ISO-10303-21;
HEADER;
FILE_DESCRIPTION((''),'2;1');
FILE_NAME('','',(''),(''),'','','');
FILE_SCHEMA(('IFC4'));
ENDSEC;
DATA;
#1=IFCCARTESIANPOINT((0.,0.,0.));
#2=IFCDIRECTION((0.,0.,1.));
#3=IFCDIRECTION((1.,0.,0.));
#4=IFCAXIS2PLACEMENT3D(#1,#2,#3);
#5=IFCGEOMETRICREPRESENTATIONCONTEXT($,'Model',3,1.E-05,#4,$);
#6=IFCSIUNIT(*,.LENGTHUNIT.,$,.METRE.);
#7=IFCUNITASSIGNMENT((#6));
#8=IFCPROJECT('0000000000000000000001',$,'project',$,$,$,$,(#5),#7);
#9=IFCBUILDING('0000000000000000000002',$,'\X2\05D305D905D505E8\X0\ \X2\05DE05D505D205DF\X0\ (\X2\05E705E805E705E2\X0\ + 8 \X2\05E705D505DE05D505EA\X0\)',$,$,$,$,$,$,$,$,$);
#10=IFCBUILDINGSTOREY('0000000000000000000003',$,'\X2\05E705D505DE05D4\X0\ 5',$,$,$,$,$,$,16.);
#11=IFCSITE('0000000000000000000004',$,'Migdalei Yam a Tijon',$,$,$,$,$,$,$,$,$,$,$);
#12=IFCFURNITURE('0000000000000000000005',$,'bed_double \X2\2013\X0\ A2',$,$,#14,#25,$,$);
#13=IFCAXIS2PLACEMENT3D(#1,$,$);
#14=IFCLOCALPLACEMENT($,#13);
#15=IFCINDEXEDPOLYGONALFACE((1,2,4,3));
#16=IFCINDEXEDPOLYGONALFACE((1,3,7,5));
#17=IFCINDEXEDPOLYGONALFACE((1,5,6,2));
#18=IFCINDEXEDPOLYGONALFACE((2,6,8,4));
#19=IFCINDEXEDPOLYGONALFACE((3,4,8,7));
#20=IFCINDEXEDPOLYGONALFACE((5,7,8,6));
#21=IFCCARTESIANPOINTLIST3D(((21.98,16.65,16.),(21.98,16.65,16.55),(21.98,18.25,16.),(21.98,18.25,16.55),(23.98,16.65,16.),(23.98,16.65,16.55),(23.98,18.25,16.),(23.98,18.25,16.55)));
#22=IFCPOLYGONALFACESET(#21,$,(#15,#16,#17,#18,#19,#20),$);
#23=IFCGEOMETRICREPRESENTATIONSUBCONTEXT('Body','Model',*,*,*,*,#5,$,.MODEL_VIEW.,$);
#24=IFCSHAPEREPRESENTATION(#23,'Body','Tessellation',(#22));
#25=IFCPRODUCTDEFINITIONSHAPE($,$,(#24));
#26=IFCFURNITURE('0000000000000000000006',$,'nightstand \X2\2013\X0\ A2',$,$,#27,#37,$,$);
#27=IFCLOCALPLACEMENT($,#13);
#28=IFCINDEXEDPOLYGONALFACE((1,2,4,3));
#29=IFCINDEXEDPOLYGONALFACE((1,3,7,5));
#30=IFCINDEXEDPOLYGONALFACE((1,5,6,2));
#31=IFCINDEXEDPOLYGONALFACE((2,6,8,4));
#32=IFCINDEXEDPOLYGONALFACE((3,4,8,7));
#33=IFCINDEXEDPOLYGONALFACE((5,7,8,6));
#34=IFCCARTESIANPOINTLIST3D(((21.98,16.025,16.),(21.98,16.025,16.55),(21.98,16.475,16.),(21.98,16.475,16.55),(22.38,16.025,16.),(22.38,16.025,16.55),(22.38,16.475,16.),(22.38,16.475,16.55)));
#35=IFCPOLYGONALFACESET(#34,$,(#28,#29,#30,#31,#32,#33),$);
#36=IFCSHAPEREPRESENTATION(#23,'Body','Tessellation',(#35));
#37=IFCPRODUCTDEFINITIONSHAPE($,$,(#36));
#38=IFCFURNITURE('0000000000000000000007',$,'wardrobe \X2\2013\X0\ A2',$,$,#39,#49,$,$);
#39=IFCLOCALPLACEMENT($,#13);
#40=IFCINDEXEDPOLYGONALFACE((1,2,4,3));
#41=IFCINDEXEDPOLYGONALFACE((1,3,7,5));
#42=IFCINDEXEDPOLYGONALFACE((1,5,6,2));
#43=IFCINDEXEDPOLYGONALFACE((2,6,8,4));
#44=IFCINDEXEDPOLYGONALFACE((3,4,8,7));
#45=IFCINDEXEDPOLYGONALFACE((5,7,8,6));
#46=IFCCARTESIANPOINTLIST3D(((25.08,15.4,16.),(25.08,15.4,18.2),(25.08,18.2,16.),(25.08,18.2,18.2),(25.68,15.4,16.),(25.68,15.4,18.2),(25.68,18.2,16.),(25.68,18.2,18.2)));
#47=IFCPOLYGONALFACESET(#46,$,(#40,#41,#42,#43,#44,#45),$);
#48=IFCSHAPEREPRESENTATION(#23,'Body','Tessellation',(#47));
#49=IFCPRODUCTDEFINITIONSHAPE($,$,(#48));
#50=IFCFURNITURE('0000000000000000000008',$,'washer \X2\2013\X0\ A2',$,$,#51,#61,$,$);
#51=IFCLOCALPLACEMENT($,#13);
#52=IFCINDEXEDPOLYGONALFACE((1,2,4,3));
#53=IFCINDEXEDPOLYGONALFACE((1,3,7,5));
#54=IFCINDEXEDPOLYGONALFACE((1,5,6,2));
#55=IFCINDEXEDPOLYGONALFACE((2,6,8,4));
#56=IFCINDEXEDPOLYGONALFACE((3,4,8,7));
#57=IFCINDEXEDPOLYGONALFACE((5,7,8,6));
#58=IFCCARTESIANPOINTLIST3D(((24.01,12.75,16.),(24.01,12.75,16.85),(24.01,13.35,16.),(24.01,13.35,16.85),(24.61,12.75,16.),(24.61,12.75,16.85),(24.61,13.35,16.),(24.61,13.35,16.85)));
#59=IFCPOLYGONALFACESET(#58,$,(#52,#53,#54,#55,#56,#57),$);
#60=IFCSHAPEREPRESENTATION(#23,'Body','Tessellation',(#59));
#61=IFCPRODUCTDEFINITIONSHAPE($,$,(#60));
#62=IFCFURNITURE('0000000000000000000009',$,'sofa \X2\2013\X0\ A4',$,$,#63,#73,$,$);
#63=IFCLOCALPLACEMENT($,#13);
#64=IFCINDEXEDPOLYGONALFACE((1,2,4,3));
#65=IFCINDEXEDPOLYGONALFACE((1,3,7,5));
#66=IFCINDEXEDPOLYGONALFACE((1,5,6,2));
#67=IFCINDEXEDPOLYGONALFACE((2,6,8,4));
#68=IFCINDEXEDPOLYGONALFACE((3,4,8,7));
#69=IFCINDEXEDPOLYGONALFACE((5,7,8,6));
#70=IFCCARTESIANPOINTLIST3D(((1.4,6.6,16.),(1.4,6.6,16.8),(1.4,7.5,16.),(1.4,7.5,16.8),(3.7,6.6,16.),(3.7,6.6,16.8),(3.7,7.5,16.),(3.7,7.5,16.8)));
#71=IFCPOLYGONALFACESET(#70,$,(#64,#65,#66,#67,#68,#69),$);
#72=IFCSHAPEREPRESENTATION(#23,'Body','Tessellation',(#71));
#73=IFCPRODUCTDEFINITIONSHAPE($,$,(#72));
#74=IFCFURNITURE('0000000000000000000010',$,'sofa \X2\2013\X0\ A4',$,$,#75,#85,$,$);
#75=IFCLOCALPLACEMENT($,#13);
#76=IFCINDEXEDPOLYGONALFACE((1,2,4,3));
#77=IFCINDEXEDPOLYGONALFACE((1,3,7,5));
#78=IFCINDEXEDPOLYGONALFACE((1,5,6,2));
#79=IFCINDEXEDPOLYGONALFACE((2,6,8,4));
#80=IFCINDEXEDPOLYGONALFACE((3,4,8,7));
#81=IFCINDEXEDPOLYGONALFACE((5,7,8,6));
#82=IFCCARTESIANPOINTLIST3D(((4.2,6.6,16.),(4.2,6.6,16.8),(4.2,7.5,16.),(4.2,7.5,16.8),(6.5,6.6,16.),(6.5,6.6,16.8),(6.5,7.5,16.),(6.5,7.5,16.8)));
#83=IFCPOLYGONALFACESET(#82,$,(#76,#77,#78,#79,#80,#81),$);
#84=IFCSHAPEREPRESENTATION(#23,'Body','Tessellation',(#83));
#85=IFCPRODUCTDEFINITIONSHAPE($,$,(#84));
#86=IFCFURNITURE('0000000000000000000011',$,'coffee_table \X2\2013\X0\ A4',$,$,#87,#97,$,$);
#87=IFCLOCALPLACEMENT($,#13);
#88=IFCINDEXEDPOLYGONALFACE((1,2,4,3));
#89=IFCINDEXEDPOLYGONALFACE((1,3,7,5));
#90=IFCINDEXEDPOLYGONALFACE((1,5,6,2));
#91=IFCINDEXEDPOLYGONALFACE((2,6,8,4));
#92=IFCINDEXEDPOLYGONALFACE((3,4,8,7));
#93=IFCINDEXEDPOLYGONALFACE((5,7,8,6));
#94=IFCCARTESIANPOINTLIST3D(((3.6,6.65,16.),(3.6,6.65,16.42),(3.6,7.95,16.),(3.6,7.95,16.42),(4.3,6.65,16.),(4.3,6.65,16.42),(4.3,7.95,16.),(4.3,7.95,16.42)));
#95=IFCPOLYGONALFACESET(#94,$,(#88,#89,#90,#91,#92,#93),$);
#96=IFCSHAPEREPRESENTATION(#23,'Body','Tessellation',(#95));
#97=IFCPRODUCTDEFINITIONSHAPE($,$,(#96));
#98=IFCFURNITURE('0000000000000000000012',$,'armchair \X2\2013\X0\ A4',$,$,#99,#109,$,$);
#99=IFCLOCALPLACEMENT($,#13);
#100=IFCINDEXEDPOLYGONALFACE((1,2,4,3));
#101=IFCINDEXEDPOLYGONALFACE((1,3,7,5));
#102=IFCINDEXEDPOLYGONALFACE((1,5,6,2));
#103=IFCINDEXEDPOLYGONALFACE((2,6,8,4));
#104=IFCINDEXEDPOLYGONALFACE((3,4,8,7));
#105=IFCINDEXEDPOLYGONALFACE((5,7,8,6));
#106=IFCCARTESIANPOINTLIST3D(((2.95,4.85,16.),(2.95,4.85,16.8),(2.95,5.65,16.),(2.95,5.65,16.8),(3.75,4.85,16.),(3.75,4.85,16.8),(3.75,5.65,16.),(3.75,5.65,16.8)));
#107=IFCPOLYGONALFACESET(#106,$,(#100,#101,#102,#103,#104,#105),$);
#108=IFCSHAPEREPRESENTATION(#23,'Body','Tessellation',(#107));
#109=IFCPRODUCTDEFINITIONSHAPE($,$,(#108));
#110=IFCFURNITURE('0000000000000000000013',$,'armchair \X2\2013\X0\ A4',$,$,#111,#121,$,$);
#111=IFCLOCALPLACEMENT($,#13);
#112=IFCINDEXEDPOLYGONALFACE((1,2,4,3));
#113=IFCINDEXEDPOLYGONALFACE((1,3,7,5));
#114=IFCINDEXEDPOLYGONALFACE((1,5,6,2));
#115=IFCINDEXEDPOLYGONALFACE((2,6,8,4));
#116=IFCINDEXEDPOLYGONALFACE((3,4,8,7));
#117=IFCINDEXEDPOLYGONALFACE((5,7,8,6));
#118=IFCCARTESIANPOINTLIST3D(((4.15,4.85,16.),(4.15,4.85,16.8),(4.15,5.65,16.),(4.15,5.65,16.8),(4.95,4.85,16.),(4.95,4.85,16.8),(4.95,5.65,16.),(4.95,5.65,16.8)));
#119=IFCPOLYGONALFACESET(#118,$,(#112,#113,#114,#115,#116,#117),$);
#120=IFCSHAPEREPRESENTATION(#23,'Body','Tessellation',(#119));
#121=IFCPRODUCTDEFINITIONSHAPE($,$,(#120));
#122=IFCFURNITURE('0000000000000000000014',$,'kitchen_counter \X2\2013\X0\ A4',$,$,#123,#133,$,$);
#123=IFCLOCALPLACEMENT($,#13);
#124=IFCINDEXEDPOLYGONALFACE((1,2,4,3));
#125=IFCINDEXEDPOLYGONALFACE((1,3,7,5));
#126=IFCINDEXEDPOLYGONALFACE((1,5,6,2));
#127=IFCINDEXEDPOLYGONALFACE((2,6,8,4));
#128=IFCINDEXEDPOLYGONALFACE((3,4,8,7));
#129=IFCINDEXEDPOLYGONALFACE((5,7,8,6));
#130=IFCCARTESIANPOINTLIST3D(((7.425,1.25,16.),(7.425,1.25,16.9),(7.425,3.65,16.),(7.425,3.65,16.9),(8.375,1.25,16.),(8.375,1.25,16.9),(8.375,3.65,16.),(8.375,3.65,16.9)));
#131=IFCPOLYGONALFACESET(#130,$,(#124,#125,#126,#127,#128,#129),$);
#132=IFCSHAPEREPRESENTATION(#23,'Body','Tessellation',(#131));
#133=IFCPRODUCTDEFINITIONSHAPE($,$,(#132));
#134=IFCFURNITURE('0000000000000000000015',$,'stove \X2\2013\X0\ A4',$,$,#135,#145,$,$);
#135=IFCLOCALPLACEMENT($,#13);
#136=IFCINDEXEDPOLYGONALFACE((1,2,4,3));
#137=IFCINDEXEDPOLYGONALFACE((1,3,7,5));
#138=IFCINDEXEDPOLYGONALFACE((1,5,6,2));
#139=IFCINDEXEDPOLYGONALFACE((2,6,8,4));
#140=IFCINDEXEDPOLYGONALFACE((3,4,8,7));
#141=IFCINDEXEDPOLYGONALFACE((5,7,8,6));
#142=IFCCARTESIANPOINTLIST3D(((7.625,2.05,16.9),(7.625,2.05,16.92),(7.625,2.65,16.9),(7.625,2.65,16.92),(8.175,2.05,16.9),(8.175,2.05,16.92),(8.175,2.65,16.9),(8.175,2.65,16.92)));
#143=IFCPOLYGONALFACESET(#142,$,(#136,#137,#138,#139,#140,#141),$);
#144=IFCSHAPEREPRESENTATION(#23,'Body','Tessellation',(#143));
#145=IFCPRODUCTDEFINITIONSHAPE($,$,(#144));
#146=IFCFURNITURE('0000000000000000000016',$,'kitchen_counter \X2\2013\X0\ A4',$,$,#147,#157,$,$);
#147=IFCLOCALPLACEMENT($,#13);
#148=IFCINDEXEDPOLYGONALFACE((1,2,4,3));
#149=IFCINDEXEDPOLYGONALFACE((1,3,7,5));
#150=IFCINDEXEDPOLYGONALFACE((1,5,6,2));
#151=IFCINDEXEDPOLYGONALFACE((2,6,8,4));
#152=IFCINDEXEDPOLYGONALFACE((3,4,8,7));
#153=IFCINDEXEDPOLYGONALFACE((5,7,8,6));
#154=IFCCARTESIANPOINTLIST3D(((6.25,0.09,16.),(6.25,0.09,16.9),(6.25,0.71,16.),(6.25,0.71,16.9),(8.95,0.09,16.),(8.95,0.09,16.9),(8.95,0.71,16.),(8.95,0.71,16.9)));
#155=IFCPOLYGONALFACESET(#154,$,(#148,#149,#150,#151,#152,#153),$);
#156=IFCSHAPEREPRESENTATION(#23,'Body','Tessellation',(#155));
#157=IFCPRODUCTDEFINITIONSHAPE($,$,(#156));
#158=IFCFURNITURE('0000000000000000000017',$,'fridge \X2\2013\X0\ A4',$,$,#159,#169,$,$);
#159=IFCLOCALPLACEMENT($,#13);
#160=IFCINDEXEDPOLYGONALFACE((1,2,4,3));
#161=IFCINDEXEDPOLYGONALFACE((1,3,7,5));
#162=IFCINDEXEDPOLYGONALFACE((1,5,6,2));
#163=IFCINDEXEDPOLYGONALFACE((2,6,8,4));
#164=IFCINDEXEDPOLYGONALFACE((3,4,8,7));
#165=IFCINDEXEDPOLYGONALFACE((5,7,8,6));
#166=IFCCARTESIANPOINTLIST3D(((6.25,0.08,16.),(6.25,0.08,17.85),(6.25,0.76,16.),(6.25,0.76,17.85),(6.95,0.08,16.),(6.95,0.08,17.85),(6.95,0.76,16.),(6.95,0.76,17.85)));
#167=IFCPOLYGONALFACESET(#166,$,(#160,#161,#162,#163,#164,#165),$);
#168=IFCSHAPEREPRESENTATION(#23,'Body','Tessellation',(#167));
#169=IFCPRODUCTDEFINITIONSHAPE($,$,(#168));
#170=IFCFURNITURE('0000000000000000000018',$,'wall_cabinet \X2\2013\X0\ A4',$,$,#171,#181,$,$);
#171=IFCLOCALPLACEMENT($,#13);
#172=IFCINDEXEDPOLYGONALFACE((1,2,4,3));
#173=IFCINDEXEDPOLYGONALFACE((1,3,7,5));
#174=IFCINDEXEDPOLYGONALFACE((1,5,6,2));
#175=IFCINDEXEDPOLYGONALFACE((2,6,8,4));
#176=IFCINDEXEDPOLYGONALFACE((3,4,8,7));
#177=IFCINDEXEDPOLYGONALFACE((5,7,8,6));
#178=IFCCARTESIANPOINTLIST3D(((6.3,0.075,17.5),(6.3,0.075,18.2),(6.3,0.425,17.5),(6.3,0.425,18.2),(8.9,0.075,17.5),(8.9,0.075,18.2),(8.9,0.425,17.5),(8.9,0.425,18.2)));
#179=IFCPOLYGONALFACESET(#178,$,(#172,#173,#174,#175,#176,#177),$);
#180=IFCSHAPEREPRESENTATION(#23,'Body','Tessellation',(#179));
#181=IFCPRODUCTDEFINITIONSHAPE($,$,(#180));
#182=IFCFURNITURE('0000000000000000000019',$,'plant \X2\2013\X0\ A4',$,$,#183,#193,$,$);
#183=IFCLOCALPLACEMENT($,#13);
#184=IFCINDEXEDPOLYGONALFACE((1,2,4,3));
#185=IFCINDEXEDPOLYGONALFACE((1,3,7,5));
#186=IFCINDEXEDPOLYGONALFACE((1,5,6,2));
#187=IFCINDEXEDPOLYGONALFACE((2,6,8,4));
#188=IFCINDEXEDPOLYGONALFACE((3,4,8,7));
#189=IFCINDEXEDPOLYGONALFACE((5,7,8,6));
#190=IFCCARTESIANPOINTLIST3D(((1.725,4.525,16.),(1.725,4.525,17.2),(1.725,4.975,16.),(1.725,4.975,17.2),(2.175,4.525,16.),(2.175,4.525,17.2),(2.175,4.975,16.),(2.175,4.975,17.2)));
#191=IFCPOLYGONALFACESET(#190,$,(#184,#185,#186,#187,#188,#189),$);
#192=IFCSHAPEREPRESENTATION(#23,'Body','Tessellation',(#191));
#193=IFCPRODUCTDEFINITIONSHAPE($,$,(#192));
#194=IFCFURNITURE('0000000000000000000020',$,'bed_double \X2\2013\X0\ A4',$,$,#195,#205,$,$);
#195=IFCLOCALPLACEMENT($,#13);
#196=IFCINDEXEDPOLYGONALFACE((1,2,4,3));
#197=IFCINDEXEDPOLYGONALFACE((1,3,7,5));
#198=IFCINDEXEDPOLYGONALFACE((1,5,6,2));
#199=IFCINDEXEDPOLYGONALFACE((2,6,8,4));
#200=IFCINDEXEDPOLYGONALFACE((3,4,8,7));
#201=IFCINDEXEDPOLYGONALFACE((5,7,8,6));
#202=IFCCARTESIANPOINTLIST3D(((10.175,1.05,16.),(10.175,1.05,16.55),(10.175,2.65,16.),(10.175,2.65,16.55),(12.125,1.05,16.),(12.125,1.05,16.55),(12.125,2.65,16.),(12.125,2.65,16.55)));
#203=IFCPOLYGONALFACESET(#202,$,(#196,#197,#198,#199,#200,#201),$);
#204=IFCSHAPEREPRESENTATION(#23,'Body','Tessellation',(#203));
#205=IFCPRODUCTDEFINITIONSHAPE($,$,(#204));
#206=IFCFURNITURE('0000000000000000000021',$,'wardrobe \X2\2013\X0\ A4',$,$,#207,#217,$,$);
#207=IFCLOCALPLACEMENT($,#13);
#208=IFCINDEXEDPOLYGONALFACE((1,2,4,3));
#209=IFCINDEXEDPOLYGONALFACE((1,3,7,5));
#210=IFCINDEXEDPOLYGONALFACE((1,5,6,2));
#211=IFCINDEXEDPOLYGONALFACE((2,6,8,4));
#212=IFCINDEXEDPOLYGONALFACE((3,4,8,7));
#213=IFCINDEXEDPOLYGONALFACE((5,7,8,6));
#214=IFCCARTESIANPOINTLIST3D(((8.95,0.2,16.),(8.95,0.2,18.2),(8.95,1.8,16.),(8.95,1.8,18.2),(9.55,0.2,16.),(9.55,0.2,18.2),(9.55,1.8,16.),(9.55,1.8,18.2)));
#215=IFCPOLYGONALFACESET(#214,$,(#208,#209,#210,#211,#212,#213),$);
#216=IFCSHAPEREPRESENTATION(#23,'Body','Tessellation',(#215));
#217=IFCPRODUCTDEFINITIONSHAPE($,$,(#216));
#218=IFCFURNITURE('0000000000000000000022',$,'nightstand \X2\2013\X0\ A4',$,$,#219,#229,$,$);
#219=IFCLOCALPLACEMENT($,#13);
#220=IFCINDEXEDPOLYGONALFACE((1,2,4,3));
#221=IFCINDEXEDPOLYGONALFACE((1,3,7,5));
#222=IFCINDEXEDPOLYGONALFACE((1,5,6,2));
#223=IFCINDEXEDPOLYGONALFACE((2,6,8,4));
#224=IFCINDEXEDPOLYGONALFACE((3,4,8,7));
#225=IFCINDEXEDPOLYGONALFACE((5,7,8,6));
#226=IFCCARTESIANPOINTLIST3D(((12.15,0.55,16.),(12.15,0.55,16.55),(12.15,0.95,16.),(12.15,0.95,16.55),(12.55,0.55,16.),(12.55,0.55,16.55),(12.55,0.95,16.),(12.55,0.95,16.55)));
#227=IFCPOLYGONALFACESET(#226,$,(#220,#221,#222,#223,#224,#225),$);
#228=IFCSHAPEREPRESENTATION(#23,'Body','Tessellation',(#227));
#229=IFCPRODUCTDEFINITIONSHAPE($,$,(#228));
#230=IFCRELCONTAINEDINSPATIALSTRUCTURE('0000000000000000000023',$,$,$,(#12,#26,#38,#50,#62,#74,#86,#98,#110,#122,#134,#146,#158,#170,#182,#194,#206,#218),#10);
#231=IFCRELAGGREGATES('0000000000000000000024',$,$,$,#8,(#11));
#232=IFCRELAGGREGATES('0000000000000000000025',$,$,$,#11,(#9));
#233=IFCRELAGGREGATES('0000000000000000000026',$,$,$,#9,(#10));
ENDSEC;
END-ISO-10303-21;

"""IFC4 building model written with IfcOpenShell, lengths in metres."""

from ifc_helpers import new_model, si_unit, frame, origin_with_axes, context, subcontext, project, spatial, line, indexed_curve, outline, extrude, element, save


model = new_model("IFC4")

# Units and contexts
model_context = context("Model", 3, precision=1e-05, world=origin_with_axes())
body_context = subcontext(model_context, "Body", "Model", "MODEL_VIEW")
ifc_project = project(units=[si_unit("LENGTHUNIT", "METRE")], contexts=[model_context])

# Site, building, storey
site = spatial("IfcSite", under=ifc_project, Name="Migdalei Yam a Tijon")
building = spatial("IfcBuilding", under=site, Name="דיור מוגן (קרקע + 8 קומות)")
storey = spatial("IfcBuildingStorey", under=building, Name="קומה 5", Elevation=16.0)

# Furniture
element("IfcFurniture", 1, inside=storey, Name="bed_double – A2", context=body_context, shape_type="SweptSolid", body=[
    extrude(outline(indexed_curve([(0.0, 0.0), (2.0, 0.0), (2.0, 1.6), (0.0, 1.6)], segments=[line(1, 2, 3, 4, 1)])), frame((21.98, 16.65, 16.0), z_axis=(0.0, 0.0, 1.0), x_axis=(1.0, 0.0, 0.0)), (0.0, 0.0, 1.0), 0.55),
])
element("IfcFurniture", 2, inside=storey, Name="nightstand – A2", context=body_context, shape_type="SweptSolid", body=[
    extrude(outline(indexed_curve([(0.0, 0.0), (0.4, 0.0), (0.4, 0.45), (0.0, 0.45)], segments=[line(1, 2, 3, 4, 1)])), frame((21.98, 16.025, 16.0), z_axis=(0.0, 0.0, 1.0), x_axis=(1.0, 0.0, 0.0)), (0.0, 0.0, 1.0), 0.55),
])
element("IfcFurniture", 3, inside=storey, Name="wardrobe – A2", context=body_context, shape_type="SweptSolid", body=[
    extrude(outline(indexed_curve([(0.0, 0.0), (0.6, 0.0), (0.6, 2.8), (0.0, 2.8)], segments=[line(1, 2, 3, 4, 1)])), frame((25.08, 15.4, 16.0), z_axis=(0.0, 0.0, 1.0), x_axis=(1.0, 0.0, 0.0)), (0.0, 0.0, 1.0), 2.2),
])
element("IfcFurniture", 4, inside=storey, Name="washer – A2", context=body_context, shape_type="SweptSolid", body=[
    extrude(outline(indexed_curve([(0.0, 0.0), (0.6, 0.0), (0.6, 0.6), (0.0, 0.6)], segments=[line(1, 2, 3, 4, 1)])), frame((24.01, 12.75, 16.0), z_axis=(0.0, 0.0, 1.0), x_axis=(1.0, 0.0, 0.0)), (0.0, 0.0, 1.0), 0.85),
])
element("IfcFurniture", 5, inside=storey, Name="sofa – A4", context=body_context, shape_type="SweptSolid", body=[
    extrude(outline(indexed_curve([(0.0, 0.0), (2.3, 0.0), (2.3, 0.9), (0.0, 0.9)], segments=[line(1, 2, 3, 4, 1)])), frame((1.4, 6.6, 16.0), z_axis=(0.0, 0.0, 1.0), x_axis=(1.0, 0.0, 0.0)), (0.0, 0.0, 1.0), 0.8),
])
element("IfcFurniture", 6, inside=storey, Name="sofa – A4", context=body_context, shape_type="SweptSolid", body=[
    extrude(outline(indexed_curve([(0.0, 0.0), (2.3, 0.0), (2.3, 0.9), (0.0, 0.9)], segments=[line(1, 2, 3, 4, 1)])), frame((4.2, 6.6, 16.0), z_axis=(0.0, 0.0, 1.0), x_axis=(1.0, 0.0, 0.0)), (0.0, 0.0, 1.0), 0.8),
])
element("IfcFurniture", 7, inside=storey, Name="coffee_table – A4", context=body_context, shape_type="SweptSolid", body=[
    extrude(outline(indexed_curve([(0.0, 0.0), (0.7, 0.0), (0.7, 1.3), (0.0, 1.3)], segments=[line(1, 2, 3, 4, 1)])), frame((3.6, 6.65, 16.0), z_axis=(0.0, 0.0, 1.0), x_axis=(1.0, 0.0, 0.0)), (0.0, 0.0, 1.0), 0.42),
])
element("IfcFurniture", 8, inside=storey, Name="armchair – A4", context=body_context, shape_type="SweptSolid", body=[
    extrude(outline(indexed_curve([(0.0, 0.0), (0.8, 0.0), (0.8, 0.8), (0.0, 0.8)], segments=[line(1, 2, 3, 4, 1)])), frame((2.95, 4.85, 16.0), z_axis=(0.0, 0.0, 1.0), x_axis=(1.0, 0.0, 0.0)), (0.0, 0.0, 1.0), 0.8),
])
element("IfcFurniture", 9, inside=storey, Name="armchair – A4", context=body_context, shape_type="SweptSolid", body=[
    extrude(outline(indexed_curve([(0.0, 0.0), (0.8, 0.0), (0.8, 0.8), (0.0, 0.8)], segments=[line(1, 2, 3, 4, 1)])), frame((4.15, 4.85, 16.0), z_axis=(0.0, 0.0, 1.0), x_axis=(1.0, 0.0, 0.0)), (0.0, 0.0, 1.0), 0.8),
])
element("IfcFurniture", 10, inside=storey, Name="kitchen_counter – A4", context=body_context, shape_type="SweptSolid", body=[
    extrude(outline(indexed_curve([(0.0, 0.0), (0.95, 0.0), (0.95, 2.4), (0.0, 2.4)], segments=[line(1, 2, 3, 4, 1)])), frame((7.425, 1.25, 16.0), z_axis=(0.0, 0.0, 1.0), x_axis=(1.0, 0.0, 0.0)), (0.0, 0.0, 1.0), 0.9),
])
element("IfcFurniture", 11, inside=storey, Name="stove – A4", context=body_context, shape_type="SweptSolid", body=[
    extrude(outline(indexed_curve([(0.0, 0.0), (0.55, 0.0), (0.55, 0.6), (0.0, 0.6)], segments=[line(1, 2, 3, 4, 1)])), frame((7.625, 2.05, 16.9), z_axis=(0.0, 0.0, 1.0), x_axis=(1.0, 0.0, 0.0)), (0.0, 0.0, 1.0), 0.02),
])
element("IfcFurniture", 12, inside=storey, Name="kitchen_counter – A4", context=body_context, shape_type="SweptSolid", body=[
    extrude(outline(indexed_curve([(0.0, 0.0), (2.7, 0.0), (2.7, 0.62), (0.0, 0.62)], segments=[line(1, 2, 3, 4, 1)])), frame((6.25, 0.09, 16.0), z_axis=(0.0, 0.0, 1.0), x_axis=(1.0, 0.0, 0.0)), (0.0, 0.0, 1.0), 0.9),
])
element("IfcFurniture", 13, inside=storey, Name="fridge – A4", context=body_context, shape_type="SweptSolid", body=[
    extrude(outline(indexed_curve([(0.0, 0.0), (0.7, 0.0), (0.7, 0.68), (0.0, 0.68)], segments=[line(1, 2, 3, 4, 1)])), frame((6.25, 0.08, 16.0), z_axis=(0.0, 0.0, 1.0), x_axis=(1.0, 0.0, 0.0)), (0.0, 0.0, 1.0), 1.85),
])
element("IfcFurniture", 14, inside=storey, Name="wall_cabinet – A4", context=body_context, shape_type="SweptSolid", body=[
    extrude(outline(indexed_curve([(0.0, 0.0), (2.6, 0.0), (2.6, 0.35), (0.0, 0.35)], segments=[line(1, 2, 3, 4, 1)])), frame((6.3, 0.075, 17.5), z_axis=(0.0, 0.0, 1.0), x_axis=(1.0, 0.0, 0.0)), (0.0, 0.0, 1.0), 0.7),
])
element("IfcFurniture", 15, inside=storey, Name="plant – A4", context=body_context, shape_type="SweptSolid", body=[
    extrude(outline(indexed_curve([(0.0, 0.0), (0.45, 0.0), (0.45, 0.45), (0.0, 0.45)], segments=[line(1, 2, 3, 4, 1)])), frame((1.725, 4.525, 16.0), z_axis=(0.0, 0.0, 1.0), x_axis=(1.0, 0.0, 0.0)), (0.0, 0.0, 1.0), 1.2),
])
element("IfcFurniture", 16, inside=storey, Name="bed_double – A4", context=body_context, shape_type="SweptSolid", body=[
    extrude(outline(indexed_curve([(0.0, 0.0), (1.95, 0.0), (1.95, 1.6), (0.0, 1.6)], segments=[line(1, 2, 3, 4, 1)])), frame((10.175, 1.05, 16.0), z_axis=(0.0, 0.0, 1.0), x_axis=(1.0, 0.0, 0.0)), (0.0, 0.0, 1.0), 0.55),
])
element("IfcFurniture", 17, inside=storey, Name="wardrobe – A4", context=body_context, shape_type="SweptSolid", body=[
    extrude(outline(indexed_curve([(0.0, 0.0), (0.6, 0.0), (0.6, 1.6), (0.0, 1.6)], segments=[line(1, 2, 3, 4, 1)])), frame((8.95, 0.2, 16.0), z_axis=(0.0, 0.0, 1.0), x_axis=(1.0, 0.0, 0.0)), (0.0, 0.0, 1.0), 2.2),
])
element("IfcFurniture", 18, inside=storey, Name="nightstand – A4", context=body_context, shape_type="SweptSolid", body=[
    extrude(outline(indexed_curve([(0.0, 0.0), (0.4, 0.0), (0.4, 0.4), (0.0, 0.4)], segments=[line(1, 2, 3, 4, 1)])), frame((12.15, 0.55, 16.0), z_axis=(0.0, 0.0, 1.0), x_axis=(1.0, 0.0, 0.0)), (0.0, 0.0, 1.0), 0.55),
])

save(model, "model.ifc")
